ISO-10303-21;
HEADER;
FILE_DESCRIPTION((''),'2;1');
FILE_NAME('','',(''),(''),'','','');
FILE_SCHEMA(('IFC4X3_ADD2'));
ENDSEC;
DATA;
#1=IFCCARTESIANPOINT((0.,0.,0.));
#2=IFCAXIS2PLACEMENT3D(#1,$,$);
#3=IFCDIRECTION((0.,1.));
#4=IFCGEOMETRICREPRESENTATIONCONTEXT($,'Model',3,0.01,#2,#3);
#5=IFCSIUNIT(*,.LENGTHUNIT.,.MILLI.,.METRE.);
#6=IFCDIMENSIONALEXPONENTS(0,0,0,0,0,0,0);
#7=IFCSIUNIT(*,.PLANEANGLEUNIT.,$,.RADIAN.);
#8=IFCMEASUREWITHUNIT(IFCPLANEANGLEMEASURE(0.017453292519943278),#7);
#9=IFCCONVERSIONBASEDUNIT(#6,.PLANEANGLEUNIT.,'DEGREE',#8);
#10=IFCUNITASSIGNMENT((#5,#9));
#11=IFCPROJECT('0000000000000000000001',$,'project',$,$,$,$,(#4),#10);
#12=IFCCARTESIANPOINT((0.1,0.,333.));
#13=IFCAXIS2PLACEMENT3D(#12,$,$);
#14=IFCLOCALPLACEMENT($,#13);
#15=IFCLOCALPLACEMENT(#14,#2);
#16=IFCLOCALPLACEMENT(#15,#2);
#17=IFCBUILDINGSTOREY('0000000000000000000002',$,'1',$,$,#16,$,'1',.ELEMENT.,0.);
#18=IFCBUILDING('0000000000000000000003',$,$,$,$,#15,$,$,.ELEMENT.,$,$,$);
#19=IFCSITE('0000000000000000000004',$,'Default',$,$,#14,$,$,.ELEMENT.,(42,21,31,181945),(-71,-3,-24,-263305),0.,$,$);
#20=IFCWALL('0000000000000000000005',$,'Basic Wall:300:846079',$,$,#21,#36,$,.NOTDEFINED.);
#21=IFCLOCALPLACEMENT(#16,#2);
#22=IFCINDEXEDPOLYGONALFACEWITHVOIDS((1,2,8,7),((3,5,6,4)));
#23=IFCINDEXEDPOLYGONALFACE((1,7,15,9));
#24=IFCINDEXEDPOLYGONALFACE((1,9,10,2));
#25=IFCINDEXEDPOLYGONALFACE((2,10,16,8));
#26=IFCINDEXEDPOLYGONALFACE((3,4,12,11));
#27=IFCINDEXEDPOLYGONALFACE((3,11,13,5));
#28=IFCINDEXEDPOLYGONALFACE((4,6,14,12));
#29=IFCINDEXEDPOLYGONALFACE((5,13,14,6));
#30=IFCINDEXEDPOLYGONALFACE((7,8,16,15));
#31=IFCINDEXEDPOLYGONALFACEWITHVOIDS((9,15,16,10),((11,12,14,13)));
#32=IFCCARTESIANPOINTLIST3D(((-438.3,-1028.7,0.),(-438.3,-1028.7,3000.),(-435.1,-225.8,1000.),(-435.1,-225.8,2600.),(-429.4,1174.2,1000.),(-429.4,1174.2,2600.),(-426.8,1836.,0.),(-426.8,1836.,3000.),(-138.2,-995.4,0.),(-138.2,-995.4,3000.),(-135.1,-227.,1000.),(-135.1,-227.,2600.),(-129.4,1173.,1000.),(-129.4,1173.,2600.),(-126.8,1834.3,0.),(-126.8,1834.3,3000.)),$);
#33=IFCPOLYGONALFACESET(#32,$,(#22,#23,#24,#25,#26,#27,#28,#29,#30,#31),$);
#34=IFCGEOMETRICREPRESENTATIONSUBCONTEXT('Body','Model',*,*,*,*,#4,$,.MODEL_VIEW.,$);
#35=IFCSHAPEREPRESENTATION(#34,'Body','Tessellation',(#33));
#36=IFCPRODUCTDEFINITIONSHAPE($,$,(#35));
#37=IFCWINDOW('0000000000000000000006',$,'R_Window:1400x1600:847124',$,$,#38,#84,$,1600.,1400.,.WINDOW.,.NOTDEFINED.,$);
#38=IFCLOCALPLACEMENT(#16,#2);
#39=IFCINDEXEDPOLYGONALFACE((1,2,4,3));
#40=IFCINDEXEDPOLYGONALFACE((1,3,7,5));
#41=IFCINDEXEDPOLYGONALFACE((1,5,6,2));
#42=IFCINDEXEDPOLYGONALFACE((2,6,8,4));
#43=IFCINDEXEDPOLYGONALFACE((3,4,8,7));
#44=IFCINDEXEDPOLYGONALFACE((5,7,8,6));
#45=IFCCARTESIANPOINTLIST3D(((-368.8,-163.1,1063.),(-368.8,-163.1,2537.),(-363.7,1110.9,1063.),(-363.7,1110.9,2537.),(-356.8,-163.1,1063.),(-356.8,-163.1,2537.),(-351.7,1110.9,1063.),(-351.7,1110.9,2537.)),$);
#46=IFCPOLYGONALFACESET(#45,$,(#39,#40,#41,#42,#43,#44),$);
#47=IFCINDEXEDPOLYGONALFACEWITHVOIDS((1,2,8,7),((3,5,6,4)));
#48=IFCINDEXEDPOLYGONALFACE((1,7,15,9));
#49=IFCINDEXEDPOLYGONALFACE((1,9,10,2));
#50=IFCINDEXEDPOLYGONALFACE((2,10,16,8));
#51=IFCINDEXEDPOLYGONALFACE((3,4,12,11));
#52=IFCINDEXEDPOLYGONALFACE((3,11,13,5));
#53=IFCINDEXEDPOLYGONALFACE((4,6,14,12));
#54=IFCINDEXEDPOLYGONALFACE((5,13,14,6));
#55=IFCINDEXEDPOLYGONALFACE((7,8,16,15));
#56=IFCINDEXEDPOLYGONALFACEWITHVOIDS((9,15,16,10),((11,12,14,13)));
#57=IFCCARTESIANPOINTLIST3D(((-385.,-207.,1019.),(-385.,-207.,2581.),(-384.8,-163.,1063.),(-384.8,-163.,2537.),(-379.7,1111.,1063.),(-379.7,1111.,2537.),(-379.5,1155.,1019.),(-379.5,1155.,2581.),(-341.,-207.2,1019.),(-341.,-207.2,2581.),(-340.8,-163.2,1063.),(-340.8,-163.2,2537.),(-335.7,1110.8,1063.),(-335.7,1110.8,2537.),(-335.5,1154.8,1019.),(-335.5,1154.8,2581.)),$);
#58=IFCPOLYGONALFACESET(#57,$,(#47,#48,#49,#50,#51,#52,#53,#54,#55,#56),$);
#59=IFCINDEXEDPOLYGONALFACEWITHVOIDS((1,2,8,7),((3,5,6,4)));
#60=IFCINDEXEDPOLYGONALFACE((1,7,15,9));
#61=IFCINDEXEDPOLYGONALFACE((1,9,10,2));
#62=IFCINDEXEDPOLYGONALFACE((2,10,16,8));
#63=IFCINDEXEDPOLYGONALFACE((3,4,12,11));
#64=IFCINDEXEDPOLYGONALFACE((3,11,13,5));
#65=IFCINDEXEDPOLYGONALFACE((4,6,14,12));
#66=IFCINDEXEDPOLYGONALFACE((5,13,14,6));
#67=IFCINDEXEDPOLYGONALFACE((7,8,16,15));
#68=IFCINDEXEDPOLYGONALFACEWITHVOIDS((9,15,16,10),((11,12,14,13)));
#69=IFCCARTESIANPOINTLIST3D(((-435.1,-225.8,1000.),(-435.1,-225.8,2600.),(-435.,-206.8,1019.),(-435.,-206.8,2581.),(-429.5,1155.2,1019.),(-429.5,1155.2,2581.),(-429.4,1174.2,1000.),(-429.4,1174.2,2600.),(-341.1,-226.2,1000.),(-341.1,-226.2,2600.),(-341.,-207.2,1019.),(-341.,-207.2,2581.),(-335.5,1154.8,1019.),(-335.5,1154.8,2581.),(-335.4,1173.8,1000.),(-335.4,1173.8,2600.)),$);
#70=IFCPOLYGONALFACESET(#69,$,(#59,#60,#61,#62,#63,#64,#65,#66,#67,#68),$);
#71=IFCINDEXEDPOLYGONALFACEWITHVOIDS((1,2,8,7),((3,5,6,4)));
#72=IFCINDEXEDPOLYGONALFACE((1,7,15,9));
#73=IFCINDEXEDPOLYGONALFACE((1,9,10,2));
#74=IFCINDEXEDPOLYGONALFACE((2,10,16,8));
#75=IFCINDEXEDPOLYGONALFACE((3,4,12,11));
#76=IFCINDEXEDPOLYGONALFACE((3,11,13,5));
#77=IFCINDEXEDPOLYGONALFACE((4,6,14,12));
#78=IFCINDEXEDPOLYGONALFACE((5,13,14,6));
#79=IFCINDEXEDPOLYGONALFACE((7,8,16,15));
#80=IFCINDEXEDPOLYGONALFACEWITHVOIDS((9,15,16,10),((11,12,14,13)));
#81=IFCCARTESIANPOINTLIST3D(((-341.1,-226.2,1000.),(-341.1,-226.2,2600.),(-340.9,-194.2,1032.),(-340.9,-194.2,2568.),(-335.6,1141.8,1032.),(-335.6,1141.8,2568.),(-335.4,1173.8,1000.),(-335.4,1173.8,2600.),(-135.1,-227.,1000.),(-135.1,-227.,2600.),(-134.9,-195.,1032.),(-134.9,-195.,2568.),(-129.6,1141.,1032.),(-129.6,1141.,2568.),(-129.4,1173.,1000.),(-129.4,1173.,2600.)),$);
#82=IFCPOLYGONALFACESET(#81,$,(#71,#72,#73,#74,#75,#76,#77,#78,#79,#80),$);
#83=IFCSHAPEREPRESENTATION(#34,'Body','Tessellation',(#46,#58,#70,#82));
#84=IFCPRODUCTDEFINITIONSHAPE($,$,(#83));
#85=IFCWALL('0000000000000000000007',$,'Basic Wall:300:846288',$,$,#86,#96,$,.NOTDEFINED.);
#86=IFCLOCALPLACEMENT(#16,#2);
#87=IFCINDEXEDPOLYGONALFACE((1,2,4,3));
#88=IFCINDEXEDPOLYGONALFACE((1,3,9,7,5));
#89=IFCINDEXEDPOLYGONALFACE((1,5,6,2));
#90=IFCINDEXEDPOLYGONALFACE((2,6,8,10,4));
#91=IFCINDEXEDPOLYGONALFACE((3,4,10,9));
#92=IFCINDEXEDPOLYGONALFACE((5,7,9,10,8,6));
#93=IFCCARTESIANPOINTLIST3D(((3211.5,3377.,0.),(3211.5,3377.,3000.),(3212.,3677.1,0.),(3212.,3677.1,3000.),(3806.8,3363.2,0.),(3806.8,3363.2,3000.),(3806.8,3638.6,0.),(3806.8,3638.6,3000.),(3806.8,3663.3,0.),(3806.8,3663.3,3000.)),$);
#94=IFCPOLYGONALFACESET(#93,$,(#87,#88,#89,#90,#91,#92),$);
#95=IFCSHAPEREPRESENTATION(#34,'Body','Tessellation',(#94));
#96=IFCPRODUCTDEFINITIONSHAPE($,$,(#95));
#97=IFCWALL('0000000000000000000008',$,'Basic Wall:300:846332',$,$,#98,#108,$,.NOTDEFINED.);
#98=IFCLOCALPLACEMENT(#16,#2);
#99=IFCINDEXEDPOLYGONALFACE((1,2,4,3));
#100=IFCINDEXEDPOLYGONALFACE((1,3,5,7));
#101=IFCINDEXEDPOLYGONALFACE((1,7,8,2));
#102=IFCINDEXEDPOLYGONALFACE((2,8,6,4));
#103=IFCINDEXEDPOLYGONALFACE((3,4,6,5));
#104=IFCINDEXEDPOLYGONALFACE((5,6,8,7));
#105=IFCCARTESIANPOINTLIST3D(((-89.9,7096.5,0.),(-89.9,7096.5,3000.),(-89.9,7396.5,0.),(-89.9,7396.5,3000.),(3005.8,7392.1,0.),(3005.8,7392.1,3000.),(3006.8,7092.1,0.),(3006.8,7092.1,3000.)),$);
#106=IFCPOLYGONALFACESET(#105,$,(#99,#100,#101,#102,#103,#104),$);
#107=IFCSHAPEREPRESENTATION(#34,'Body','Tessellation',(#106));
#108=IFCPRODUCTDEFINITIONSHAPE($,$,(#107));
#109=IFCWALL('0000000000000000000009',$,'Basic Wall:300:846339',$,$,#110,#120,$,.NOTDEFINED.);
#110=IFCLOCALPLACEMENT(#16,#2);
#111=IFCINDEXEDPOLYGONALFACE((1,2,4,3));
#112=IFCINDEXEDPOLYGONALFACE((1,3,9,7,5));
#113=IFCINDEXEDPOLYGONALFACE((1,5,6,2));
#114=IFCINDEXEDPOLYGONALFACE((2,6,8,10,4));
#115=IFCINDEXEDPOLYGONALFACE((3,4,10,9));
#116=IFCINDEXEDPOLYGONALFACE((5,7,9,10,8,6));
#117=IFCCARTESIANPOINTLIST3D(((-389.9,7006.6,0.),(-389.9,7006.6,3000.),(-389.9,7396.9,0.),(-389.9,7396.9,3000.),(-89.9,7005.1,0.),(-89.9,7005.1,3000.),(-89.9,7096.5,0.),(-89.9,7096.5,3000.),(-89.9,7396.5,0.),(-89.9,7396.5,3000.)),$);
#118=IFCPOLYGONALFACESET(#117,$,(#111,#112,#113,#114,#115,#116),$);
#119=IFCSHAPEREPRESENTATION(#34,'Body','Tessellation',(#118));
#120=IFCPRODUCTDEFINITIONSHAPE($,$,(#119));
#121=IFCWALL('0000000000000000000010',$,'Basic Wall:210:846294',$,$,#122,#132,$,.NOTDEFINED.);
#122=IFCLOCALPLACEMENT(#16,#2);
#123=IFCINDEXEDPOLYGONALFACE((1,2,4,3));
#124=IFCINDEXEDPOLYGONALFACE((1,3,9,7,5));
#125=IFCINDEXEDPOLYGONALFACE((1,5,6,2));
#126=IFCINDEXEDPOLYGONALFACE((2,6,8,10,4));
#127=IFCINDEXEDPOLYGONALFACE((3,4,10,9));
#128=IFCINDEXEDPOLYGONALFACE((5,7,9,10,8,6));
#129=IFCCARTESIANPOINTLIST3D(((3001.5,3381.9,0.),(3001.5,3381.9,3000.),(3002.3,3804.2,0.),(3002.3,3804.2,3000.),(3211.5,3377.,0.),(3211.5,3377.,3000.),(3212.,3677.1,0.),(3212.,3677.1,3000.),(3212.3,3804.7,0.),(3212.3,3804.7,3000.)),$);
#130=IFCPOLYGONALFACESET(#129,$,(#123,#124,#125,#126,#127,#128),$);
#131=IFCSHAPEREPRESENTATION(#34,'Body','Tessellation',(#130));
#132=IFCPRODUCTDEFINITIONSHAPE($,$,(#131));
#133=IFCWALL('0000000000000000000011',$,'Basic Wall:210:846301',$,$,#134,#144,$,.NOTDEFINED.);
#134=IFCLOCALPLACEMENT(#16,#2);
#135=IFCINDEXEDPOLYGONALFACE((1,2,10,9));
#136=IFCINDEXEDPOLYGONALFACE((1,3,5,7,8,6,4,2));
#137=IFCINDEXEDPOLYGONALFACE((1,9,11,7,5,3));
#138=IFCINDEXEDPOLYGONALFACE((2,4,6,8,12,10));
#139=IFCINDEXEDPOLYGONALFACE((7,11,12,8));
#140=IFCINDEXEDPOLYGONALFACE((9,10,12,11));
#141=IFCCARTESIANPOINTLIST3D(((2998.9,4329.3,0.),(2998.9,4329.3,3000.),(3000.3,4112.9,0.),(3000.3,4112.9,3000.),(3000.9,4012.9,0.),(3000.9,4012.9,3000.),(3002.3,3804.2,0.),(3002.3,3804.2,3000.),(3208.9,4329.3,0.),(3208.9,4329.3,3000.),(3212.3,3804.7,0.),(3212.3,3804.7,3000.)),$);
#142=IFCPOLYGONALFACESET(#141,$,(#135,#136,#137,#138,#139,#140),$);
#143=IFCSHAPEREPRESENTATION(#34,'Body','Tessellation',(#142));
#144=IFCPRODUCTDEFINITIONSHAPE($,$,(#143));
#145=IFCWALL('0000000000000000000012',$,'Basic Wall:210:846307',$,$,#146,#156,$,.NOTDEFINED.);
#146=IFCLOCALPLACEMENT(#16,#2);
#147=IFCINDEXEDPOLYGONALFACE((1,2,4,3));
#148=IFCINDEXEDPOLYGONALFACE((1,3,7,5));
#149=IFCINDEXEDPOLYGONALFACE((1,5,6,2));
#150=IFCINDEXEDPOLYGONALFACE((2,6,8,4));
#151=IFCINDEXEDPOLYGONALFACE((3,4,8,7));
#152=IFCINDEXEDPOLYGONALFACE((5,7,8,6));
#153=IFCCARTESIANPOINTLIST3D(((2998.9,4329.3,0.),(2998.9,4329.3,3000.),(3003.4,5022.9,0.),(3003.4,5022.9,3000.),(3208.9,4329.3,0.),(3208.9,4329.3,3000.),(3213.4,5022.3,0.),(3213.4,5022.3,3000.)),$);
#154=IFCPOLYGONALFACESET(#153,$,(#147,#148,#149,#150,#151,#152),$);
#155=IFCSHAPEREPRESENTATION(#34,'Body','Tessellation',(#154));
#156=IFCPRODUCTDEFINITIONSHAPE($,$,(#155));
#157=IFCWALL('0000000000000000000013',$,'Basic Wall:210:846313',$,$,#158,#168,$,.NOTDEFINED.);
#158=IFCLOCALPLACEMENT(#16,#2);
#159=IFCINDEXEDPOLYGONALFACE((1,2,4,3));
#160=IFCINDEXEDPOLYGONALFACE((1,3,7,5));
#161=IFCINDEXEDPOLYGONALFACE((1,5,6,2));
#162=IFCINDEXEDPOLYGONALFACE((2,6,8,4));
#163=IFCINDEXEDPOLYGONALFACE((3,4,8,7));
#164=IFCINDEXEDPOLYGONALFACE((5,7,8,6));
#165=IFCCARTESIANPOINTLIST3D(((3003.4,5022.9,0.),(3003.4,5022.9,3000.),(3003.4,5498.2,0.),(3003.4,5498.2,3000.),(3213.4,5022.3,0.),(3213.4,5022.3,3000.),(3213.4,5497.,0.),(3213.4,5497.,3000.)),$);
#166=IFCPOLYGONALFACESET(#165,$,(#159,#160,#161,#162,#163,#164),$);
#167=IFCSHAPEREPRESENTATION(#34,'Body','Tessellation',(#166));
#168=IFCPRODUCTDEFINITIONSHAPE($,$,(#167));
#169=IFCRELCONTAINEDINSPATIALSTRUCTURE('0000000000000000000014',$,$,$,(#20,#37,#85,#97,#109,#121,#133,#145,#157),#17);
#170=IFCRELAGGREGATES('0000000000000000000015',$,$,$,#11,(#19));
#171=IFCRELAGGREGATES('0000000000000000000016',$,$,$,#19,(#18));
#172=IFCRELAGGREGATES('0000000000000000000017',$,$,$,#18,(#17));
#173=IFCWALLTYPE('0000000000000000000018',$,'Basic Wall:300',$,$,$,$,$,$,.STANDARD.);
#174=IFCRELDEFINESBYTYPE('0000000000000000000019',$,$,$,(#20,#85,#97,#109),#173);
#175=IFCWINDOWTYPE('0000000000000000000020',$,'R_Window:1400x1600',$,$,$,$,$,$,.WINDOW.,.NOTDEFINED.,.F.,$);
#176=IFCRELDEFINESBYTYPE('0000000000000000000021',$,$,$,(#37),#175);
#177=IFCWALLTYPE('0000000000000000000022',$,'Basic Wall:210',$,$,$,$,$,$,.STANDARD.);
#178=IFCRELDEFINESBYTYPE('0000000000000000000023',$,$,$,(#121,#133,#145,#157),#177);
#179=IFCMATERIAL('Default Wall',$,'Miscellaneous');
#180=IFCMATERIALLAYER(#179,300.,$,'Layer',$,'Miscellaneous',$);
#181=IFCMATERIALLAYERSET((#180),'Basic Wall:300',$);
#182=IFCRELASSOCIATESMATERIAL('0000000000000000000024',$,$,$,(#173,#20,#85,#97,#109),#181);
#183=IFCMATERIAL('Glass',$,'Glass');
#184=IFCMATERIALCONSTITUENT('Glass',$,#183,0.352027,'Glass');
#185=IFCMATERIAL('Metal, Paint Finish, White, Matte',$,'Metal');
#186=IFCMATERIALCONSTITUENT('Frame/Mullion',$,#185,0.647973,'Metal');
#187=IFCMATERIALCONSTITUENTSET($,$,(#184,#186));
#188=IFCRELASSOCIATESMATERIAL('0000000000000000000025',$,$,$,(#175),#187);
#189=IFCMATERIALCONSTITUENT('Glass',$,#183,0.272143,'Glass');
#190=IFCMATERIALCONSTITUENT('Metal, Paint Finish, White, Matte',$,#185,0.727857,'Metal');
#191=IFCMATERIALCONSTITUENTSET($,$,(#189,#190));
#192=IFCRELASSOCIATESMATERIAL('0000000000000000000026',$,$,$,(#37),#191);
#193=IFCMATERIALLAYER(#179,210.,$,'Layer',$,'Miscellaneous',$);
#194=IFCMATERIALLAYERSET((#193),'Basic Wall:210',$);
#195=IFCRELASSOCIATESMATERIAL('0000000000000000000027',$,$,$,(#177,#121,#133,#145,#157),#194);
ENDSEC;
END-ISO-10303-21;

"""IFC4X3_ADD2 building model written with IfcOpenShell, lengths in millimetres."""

from ifc_helpers import new_model, entity, si_unit, converted_unit, direction, frame, frame_2d, origin, place, context, subcontext, project, spatial, polyline, rectangle, outline, extrude, source, transform, mapped, material, layer, layer_set, constituent, constituent_set, type_object, type_shapes, element, fill, save


model = new_model("IFC4X3_ADD2")

# Units and contexts
model_context = context("Model", 3, precision=0.01, world=origin(), true_north=direction((0.0, 1.0)))
body_context = subcontext(model_context, "Body", "Model", "MODEL_VIEW")
ifc_project = project(units=[si_unit("LENGTHUNIT", "METRE", prefix="MILLI"), converted_unit("PLANEANGLEUNIT", "DEGREE", entity("IfcPlaneAngleMeasure", 0.017453292519943278), si_unit("PLANEANGLEUNIT", "RADIAN"), dimensions=[0, 0, 0, 0, 0, 0, 0])], contexts=[model_context])

# Site, building, storey
site_placement = place(None, frame((0.1, 0.0, 333.0)))
site = spatial("IfcSite", under=ifc_project, at=site_placement, Name="Default", CompositionType="ELEMENT", RefLatitude=(42, 21, 31, 181945), RefLongitude=(-71, -3, -24, -263305), RefElevation=0.0)
building_placement = place(site_placement, origin())
building = spatial("IfcBuilding", under=site, at=building_placement, CompositionType="ELEMENT")
storey_placement = place(building_placement, origin())
storey = spatial("IfcBuildingStorey", under=building, at=storey_placement, Name="1", LongName="1", CompositionType="ELEMENT", Elevation=0.0)

# Shared definitions
ifc_material_1 = material(Name="Default Wall", Category="Miscellaneous")
ifc_layer_1 = layer(ifc_material_1, 300.0, Name="Layer", Category="Miscellaneous")
ifc_layer_set_1 = layer_set([ifc_layer_1], Name="Basic Wall:300")
wall_type_1 = type_object("IfcWallType", Name="Basic Wall:300", PredefinedType="STANDARD", material=ifc_layer_set_1)
ifc_material_2 = material(Name="Glass", Category="Glass")
ifc_material_3 = material(Name="Metal, Paint Finish, White, Matte", Category="Metal")
ifc_constituent_1 = constituent(ifc_material_2, Name="Glass", Category="Glass", fraction=0.352027)
ifc_constituent_2 = constituent(ifc_material_3, Name="Frame/Mullion", Category="Metal", fraction=0.647973)
ifc_constituent_set_1 = constituent_set(constituents=[ifc_constituent_1, ifc_constituent_2])
window_type = type_object("IfcWindowType", Name="R_Window:1400x1600", ParameterTakesPrecedence=False, PartitioningType="NOTDEFINED", PredefinedType="WINDOW", material=ifc_constituent_set_1)
shared_shape_1 = source(origin(), body_context, "Body", "SweptSolid", [
    extrude(rectangle(XDim=12.0, YDim=1274.0, at=frame_2d((0.0, 0.0), x_axis=(1.0, 0.0))), frame((700.0, 228.0, 63.0), z_axis=(0.0, 0.0, 1.0), x_axis=(0.0, -1.0, 0.0)), (0.0, 0.0, 1.0), 1474.0),
    extrude(outline(polyline([(-681.0, -781.0), (681.0, -781.0), (681.0, 781.0), (-681.0, 781.0), (-681.0, -781.0)]), holes=[polyline([(-637.0, -737.0), (-637.0, 737.0), (637.0, 737.0), (637.0, -737.0), (-637.0, -737.0)])]), frame((700.0, 206.0, 800.0), z_axis=(0.0, 1.0, 0.0), x_axis=(1.0, 0.0, 0.0)), (0.0, 0.0, 1.0), 44.0),
    extrude(outline(polyline([(-700.0, -800.0), (700.0, -800.0), (700.0, 800.0), (-700.0, 800.0), (-700.0, -800.0)]), holes=[polyline([(-681.0, -781.0), (-681.0, 781.0), (681.0, 781.0), (681.0, -781.0), (-681.0, -781.0)])]), frame((700.0, 206.0, 800.0), z_axis=(0.0, 1.0, 0.0), x_axis=(1.0, 0.0, 0.0)), (0.0, 0.0, 1.0), 94.0),
    extrude(outline(polyline([(-700.0, -800.0), (700.0, -800.0), (700.0, 800.0), (-700.0, 800.0), (-700.0, -800.0)]), holes=[polyline([(-668.0, -768.0), (-668.0, 768.0), (668.0, 768.0), (668.0, -768.0), (-668.0, -768.0)])]), frame((700.0, 0.0, 800.0), z_axis=(0.0, 1.0, 0.0), x_axis=(1.0, 0.0, 0.0)), (0.0, 0.0, 1.0), 206.0),
])
type_shapes(window_type, [shared_shape_1])

# Wall, opening, window
wall_1_placement = place(storey_placement, frame((-288.3, -1029.3, 0.0), z_axis=(0.0, 0.0, 1.0), x_axis=(0.004036, 0.999992, 0.0)))
wall_1 = element("IfcWall", 1, at=wall_1_placement, inside=storey, type_object=wall_type_1, material=ifc_layer_set_1, Name="Basic Wall:300:846079", PredefinedType="NOTDEFINED", context=body_context, shape_type="SweptSolid", body=[
    extrude(outline(polyline([(2864.2, -150.0), (2864.7, 150.0), (0.0, 150.0), (34.5, -150.0), (336.5, -150.0), (2864.2, -150.0)])), origin(), (0.0, 0.0, 1.0), 3000.0),
])
opening_1_placement = place(wall_1_placement, frame((802.9, -150.0, 1000.0)))
opening_1 = element("IfcOpeningElement", 2, at=opening_1_placement, cuts=wall_1, PredefinedType="OPENING", context=body_context, shape_type="SweptSolid", body=[
    extrude(rectangle(XDim=1600.0, YDim=1400.0, at=frame_2d((800.0, 700.0), x_axis=(1.0, 0.0))), frame((0.0, 0.0, 0.0), z_axis=(0.0, 1.0, 0.0), x_axis=(0.0, 0.0, 1.0)), (0.0, 0.0, 1.0), 300.0),
])
ifc_constituent_3 = constituent(ifc_material_2, Name="Glass", Category="Glass", fraction=0.272143)
ifc_constituent_4 = constituent(ifc_material_3, Name="Metal, Paint Finish, White, Matte", Category="Metal", fraction=0.727857)
ifc_constituent_set_2 = constituent_set(constituents=[ifc_constituent_3, ifc_constituent_4])
window_1_placement = place(opening_1_placement, origin())
window_1 = element("IfcWindow", 3, at=window_1_placement, inside=storey, type_object=window_type, material=ifc_constituent_set_2, Name="R_Window:1400x1600:847124", OverallHeight=1600.0, OverallWidth=1400.0, PartitioningType="NOTDEFINED", PredefinedType="WINDOW", context=body_context, shape_type="MappedRepresentation", body=[
    mapped(shared_shape_1, transform((0.0, 0.0, 0.0), scale=1.0)),
])
fill(opening_1, window_1)

# Walls
wall_2_placement = place(storey_placement, frame((3208.5, 3527.1, 0.0), z_axis=(0.0, 0.0, 1.0), x_axis=(0.999732, -0.023142, 0.0)))
element("IfcWall", 4, at=wall_2_placement, inside=storey, type_object=wall_type_1, material=ifc_layer_set_1, Name="Basic Wall:300:846288", PredefinedType="NOTDEFINED", context=body_context, shape_type="SweptSolid", body=[
    extrude(outline(polyline([(601.9, -150.0), (595.5, 125.3), (594.9, 150.0), (0.0, 150.0), (6.4, -150.0), (601.9, -150.0)])), origin(), (0.0, 0.0, 1.0), 3000.0),
])
wall_3_placement = place(storey_placement, frame((-90.1, 7246.5, 0.0), z_axis=(0.0, 0.0, 1.0), x_axis=(0.999999, -0.001405, 0.0)))
element("IfcWall", 5, at=wall_3_placement, inside=storey, type_object=wall_type_1, material=ifc_layer_set_1, Name="Basic Wall:300:846332", PredefinedType="NOTDEFINED", context=body_context, shape_type="SweptSolid", body=[
    extrude(outline(polyline([(3097.2, -150.0), (3095.7, 150.0), (0.0, 150.0), (0.4, -150.0), (3097.2, -150.0)])), origin(), (0.0, 0.0, 1.0), 3000.0),
])
wall_4_placement = place(storey_placement, frame((-239.9, 7005.1, 0.0), z_axis=(0.0, 0.0, 1.0), x_axis=(0.0, 1.0, 0.0)))
element("IfcWall", 6, at=wall_4_placement, inside=storey, type_object=wall_type_1, material=ifc_layer_set_1, Name="Basic Wall:300:846339", PredefinedType="NOTDEFINED", context=body_context, shape_type="SweptSolid", body=[
    extrude(outline(polyline([(391.4, -150.0), (391.8, 150.0), (1.5, 150.0), (0.0, -150.0), (91.4, -150.0), (391.4, -150.0)])), origin(), (0.0, 0.0, 1.0), 3000.0),
])
ifc_layer_2 = layer(ifc_material_1, 210.0, Name="Layer", Category="Miscellaneous")
ifc_layer_set_2 = layer_set([ifc_layer_2], Name="Basic Wall:210")
wall_type_2 = type_object("IfcWallType", Name="Basic Wall:210", PredefinedType="STANDARD", material=ifc_layer_set_2)
wall_5_placement = place(storey_placement, frame((3107.3, 3804.9, 0.0), z_axis=(0.0, 0.0, 1.0), x_axis=(-0.001842, -0.999998, 0.0)))
element("IfcWall", 7, at=wall_5_placement, inside=storey, type_object=wall_type_2, material=ifc_layer_set_2, Name="Basic Wall:210:846294", PredefinedType="NOTDEFINED", context=body_context, shape_type="SweptSolid", body=[
    extrude(outline(polyline([(423.2, -105.0), (427.7, 105.0), (127.6, 105.0), (0.0, 105.0), (0.9, -105.0), (423.2, -105.0)])), origin(), (0.0, 0.0, 1.0), 3000.0),
])
wall_6_placement = place(storey_placement, frame((3103.9, 4330.0, 0.0), z_axis=(0.0, 0.0, 1.0), x_axis=(0.006465, -0.999979, 0.0)))
element("IfcWall", 8, at=wall_6_placement, inside=storey, type_object=wall_type_2, material=ifc_layer_set_2, Name="Basic Wall:210:846301", PredefinedType="NOTDEFINED", context=body_context, shape_type="SweptSolid", body=[
    extrude(outline(polyline([(525.1, -105.0), (525.9, 105.0), (1.4, 105.0), (0.0, -105.0), (216.4, -105.0), (316.4, -105.0), (525.1, -105.0)])), origin(), (0.0, 0.0, 1.0), 3000.0),
])
wall_7_placement = place(storey_placement, frame((3108.4, 5022.9, 0.0), z_axis=(0.0, 0.0, 1.0), x_axis=(-0.006525, -0.999979, 0.0)))
element("IfcWall", 9, at=wall_7_placement, inside=storey, type_object=wall_type_2, material=ifc_layer_set_2, Name="Basic Wall:210:846307", PredefinedType="NOTDEFINED", context=body_context, shape_type="SweptSolid", body=[
    extrude(outline(polyline([(694.4, -105.0), (693.0, 105.0), (0.0, 105.0), (0.7, -105.0), (694.4, -105.0)])), origin(), (0.0, 0.0, 1.0), 3000.0),
])
wall_8_placement = place(storey_placement, frame((3108.4, 5498.2, 0.0), z_axis=(0.0, 0.0, 1.0), x_axis=(0.0, -1.0, 0.0)))
element("IfcWall", 10, at=wall_8_placement, inside=storey, type_object=wall_type_2, material=ifc_layer_set_2, Name="Basic Wall:210:846313", PredefinedType="NOTDEFINED", context=body_context, shape_type="SweptSolid", body=[
    extrude(outline(polyline([(475.3, -105.0), (475.9, 105.0), (1.2, 105.0), (0.0, -105.0), (475.3, -105.0)])), origin(), (0.0, 0.0, 1.0), 3000.0),
])

save(model, "model.ifc")
